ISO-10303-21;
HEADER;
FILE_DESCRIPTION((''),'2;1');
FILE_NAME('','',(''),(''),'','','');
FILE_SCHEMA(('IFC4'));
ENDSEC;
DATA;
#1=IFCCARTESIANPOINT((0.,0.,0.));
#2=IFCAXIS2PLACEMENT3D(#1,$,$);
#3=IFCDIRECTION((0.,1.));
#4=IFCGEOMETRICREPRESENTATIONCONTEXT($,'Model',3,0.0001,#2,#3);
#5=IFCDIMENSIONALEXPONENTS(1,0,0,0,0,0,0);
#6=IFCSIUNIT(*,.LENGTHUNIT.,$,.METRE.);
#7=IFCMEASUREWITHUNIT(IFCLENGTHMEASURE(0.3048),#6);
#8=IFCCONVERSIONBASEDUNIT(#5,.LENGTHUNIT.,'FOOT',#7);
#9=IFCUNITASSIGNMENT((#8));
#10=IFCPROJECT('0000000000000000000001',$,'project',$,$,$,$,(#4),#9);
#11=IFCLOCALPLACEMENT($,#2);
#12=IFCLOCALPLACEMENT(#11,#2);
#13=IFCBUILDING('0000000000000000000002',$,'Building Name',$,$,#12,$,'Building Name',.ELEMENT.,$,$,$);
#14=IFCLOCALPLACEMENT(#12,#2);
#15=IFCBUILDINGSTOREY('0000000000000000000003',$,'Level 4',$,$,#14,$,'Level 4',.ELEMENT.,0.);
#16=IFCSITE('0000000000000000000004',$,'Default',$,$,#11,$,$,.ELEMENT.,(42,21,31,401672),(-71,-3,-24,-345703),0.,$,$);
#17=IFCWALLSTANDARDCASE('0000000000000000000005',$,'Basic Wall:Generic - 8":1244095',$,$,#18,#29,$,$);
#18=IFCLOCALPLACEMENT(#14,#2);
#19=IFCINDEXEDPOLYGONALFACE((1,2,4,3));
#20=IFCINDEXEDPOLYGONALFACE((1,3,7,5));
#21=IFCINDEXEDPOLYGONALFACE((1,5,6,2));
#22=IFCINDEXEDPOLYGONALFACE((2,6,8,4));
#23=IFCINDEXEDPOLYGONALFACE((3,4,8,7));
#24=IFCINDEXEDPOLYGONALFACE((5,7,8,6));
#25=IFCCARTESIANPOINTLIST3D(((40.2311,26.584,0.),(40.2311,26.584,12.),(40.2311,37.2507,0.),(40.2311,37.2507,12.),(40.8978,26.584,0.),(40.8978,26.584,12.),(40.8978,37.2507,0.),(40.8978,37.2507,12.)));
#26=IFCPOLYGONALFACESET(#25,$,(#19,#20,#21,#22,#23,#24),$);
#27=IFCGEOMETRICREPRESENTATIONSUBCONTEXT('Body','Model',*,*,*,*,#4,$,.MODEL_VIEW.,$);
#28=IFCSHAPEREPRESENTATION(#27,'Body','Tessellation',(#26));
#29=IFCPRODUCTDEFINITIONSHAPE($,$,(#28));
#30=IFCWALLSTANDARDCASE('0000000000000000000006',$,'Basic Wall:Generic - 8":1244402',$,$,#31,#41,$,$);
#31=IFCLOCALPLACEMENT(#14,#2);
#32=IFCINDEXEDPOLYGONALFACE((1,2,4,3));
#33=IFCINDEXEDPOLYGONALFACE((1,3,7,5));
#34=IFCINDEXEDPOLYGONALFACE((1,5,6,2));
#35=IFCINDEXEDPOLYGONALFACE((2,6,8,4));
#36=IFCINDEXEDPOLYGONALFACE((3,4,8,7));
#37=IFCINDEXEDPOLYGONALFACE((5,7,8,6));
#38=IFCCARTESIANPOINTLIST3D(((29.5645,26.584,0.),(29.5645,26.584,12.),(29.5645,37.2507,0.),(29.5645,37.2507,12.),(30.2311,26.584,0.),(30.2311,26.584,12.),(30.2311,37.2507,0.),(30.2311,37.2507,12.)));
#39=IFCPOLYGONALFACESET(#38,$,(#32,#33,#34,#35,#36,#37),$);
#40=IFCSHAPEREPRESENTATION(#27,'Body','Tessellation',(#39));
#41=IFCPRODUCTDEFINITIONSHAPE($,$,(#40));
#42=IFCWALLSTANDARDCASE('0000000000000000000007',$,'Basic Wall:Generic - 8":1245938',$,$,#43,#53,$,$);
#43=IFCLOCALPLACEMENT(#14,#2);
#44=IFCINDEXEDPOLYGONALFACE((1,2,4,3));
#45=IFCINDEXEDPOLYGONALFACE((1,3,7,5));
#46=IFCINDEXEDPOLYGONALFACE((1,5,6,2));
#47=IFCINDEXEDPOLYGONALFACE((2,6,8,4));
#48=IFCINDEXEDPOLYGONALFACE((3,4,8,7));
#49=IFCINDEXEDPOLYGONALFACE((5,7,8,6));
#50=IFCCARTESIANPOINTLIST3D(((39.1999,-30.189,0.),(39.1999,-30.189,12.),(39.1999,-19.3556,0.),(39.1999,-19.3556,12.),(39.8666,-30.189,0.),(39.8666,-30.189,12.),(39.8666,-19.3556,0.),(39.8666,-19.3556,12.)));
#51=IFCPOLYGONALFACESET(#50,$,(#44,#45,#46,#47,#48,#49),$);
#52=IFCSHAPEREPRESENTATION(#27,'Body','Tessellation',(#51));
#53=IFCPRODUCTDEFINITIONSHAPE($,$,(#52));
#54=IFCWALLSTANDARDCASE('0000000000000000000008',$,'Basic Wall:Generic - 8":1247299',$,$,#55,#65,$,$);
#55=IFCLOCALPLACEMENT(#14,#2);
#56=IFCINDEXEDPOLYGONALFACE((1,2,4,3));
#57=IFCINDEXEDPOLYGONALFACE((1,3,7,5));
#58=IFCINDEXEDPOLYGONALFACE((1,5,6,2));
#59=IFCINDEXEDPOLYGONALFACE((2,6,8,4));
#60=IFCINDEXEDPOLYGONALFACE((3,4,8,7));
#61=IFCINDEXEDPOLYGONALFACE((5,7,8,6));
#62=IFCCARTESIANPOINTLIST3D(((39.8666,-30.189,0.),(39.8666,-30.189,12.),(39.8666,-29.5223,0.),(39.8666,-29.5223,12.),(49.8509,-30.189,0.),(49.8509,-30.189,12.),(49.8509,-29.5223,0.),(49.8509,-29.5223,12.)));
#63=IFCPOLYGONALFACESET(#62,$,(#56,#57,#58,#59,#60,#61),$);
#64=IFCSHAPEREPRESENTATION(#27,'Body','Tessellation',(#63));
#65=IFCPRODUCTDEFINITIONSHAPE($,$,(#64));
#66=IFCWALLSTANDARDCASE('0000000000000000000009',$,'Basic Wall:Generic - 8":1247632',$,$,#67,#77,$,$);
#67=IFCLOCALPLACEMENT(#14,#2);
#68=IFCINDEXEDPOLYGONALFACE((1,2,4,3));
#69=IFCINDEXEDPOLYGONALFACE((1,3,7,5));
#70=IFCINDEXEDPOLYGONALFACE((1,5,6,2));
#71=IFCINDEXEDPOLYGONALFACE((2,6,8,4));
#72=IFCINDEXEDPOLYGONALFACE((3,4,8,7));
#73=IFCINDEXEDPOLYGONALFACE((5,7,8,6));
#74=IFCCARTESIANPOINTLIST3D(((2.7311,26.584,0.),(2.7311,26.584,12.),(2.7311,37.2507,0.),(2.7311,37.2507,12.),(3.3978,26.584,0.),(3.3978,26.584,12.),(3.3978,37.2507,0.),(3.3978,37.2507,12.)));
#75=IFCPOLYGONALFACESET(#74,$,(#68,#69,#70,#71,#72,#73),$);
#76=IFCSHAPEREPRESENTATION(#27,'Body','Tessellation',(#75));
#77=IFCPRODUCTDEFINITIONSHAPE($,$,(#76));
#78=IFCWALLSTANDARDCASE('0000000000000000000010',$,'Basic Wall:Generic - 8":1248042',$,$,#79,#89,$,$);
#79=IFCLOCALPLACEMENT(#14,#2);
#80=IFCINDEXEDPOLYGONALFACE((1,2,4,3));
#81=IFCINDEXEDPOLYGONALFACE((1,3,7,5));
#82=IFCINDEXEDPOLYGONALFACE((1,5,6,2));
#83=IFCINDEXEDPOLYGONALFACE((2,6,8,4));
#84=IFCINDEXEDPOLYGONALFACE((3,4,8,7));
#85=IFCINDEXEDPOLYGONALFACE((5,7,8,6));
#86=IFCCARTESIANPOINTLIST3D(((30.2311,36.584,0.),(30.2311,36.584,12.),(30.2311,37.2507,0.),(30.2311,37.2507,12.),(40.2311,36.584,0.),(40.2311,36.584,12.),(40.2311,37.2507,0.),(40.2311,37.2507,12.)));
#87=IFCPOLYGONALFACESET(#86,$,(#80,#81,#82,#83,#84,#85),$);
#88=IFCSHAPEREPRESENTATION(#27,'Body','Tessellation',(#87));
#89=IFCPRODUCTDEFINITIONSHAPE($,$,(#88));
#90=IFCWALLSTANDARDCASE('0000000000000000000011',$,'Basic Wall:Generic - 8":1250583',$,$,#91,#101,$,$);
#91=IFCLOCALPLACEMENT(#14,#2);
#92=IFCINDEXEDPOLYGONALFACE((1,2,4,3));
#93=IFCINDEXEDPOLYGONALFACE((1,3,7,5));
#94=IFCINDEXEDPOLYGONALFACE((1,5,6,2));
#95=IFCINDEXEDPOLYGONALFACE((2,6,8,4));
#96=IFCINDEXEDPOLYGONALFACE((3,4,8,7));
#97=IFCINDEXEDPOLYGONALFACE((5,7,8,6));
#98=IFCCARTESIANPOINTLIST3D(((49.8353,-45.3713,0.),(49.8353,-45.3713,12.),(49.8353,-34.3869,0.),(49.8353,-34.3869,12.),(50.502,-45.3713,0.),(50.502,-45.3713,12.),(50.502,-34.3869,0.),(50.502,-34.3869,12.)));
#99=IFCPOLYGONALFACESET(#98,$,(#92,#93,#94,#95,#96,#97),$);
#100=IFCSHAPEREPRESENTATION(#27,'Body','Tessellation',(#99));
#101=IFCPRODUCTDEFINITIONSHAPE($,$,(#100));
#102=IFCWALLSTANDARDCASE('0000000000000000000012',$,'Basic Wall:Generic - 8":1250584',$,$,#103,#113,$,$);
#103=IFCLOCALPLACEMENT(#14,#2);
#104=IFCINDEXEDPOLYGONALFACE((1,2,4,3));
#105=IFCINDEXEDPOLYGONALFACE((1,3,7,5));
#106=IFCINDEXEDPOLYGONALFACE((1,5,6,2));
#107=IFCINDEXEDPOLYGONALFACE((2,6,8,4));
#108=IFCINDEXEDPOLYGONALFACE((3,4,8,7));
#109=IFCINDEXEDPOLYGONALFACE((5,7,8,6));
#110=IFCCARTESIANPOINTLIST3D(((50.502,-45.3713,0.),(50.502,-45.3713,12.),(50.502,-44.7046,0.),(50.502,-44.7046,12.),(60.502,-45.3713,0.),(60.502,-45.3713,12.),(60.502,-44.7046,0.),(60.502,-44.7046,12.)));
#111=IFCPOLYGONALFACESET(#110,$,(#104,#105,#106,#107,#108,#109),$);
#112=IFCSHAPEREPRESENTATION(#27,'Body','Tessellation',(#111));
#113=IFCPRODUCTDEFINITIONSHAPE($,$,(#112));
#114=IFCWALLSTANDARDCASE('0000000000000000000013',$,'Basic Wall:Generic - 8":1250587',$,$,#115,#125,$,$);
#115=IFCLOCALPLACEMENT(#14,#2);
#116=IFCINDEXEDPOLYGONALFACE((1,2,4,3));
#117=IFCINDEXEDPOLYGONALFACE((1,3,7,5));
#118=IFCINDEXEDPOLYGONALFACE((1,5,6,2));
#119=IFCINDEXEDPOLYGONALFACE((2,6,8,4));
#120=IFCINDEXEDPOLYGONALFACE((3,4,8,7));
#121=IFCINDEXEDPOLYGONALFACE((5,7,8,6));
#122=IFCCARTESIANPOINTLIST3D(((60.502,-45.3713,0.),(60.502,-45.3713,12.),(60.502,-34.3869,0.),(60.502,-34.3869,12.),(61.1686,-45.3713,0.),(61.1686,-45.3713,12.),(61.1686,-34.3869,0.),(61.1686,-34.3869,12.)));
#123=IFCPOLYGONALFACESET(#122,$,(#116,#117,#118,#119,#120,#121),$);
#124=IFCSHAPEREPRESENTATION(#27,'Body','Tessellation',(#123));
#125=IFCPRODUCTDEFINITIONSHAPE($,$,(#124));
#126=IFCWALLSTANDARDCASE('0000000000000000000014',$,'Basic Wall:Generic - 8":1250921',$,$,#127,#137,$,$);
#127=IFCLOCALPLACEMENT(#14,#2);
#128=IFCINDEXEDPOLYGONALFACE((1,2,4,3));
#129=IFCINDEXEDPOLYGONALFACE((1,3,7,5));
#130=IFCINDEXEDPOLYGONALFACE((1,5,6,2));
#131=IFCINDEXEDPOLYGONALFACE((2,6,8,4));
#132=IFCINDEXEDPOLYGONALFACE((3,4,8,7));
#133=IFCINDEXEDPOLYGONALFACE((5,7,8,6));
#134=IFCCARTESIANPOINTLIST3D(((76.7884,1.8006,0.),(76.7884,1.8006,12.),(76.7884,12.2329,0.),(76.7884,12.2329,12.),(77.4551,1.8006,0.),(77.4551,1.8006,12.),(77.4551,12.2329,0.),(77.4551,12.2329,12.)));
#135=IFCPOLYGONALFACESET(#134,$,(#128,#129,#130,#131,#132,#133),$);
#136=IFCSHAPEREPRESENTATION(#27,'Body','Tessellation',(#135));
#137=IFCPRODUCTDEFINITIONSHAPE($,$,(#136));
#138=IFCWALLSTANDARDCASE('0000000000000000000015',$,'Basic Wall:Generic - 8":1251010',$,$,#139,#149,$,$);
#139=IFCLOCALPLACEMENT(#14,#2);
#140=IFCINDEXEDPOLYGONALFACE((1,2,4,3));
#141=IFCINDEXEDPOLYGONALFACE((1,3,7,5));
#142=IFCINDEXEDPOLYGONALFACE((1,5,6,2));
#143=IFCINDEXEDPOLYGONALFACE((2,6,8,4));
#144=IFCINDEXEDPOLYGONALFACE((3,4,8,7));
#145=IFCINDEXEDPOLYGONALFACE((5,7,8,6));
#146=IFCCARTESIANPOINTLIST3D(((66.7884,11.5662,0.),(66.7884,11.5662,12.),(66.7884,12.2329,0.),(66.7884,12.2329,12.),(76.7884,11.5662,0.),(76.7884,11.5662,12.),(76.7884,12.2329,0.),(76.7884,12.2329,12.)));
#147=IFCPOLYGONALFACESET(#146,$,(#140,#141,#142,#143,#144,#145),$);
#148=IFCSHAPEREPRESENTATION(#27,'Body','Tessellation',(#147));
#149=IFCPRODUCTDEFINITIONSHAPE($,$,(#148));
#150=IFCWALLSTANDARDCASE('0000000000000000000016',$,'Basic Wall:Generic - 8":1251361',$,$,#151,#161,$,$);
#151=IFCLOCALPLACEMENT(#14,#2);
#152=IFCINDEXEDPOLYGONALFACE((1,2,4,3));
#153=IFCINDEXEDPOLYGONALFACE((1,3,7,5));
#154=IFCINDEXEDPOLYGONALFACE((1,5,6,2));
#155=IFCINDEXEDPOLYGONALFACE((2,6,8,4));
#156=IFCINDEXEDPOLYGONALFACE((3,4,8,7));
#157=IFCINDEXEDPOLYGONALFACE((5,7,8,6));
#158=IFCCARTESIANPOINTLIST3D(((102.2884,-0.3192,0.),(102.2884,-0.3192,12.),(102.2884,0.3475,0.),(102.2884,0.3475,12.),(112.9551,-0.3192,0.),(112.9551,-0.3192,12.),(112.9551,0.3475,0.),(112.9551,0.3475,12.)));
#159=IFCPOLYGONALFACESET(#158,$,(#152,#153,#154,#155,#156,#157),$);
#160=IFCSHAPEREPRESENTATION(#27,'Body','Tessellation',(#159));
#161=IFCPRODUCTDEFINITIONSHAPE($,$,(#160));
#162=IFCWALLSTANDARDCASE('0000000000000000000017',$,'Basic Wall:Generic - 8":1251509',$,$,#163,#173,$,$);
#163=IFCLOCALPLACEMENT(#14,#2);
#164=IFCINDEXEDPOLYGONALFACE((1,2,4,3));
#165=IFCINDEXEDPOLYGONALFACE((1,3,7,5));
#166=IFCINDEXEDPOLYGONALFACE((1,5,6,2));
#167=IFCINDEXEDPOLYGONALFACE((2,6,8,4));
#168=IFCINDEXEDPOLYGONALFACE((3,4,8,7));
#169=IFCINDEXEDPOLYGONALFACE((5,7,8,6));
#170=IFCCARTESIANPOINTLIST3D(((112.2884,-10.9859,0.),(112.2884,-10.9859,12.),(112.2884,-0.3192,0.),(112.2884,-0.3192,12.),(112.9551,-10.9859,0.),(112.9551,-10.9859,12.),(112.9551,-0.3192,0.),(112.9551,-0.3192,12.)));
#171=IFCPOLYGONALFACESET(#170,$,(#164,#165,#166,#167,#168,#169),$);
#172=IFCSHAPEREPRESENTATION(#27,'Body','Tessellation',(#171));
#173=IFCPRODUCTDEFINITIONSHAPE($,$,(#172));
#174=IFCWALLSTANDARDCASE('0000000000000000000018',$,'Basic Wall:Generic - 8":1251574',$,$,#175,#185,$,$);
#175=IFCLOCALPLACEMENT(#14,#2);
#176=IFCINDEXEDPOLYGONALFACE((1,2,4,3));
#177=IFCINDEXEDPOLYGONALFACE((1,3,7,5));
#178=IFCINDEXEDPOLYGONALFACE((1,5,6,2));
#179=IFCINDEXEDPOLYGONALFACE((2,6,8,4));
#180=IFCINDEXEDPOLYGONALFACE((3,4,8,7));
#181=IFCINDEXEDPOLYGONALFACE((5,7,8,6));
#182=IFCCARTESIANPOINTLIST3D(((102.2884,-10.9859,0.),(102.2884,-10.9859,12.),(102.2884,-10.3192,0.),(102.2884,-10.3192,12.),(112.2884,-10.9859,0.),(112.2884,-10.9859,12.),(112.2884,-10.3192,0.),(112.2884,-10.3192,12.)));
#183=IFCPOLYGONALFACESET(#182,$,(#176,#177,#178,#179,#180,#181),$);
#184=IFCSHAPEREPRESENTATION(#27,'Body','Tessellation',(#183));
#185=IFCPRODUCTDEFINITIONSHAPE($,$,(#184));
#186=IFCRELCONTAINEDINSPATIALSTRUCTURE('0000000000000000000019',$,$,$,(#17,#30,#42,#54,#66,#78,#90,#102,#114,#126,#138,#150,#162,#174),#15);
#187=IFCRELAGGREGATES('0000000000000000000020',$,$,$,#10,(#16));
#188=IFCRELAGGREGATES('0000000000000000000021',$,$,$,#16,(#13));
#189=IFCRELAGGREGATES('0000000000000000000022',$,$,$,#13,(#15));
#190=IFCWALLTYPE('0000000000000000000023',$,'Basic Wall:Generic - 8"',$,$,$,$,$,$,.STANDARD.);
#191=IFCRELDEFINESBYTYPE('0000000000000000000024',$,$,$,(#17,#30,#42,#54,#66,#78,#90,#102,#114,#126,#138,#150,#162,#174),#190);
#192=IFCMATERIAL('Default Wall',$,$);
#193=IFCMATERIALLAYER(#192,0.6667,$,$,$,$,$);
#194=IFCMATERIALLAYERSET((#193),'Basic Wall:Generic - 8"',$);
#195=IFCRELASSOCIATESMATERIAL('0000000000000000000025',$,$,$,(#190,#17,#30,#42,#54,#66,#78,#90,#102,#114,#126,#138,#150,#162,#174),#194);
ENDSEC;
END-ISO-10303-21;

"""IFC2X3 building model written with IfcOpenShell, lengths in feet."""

from ifc_helpers import new_model, entity, si_unit, converted_unit, direction, frame, frame_2d, origin, place, context, subcontext, project, spatial, rectangle, extrude, material, layer, layer_set, layer_usage, type_object, element, save


model = new_model("IFC2X3")

# Units and contexts
model_context = context("Model", 3, precision=0.0001, world=origin(), true_north=direction((0.0, 1.0)))
body_context = subcontext(model_context, "Body", "Model", "MODEL_VIEW")
ifc_project = project(units=[converted_unit("LENGTHUNIT", "FOOT", entity("IfcLengthMeasure", 0.3048), si_unit("LENGTHUNIT", "METRE"), dimensions=[1, 0, 0, 0, 0, 0, 0])], contexts=[model_context])

# Site, building, storey
site_placement = place(None, origin())
site = spatial("IfcSite", under=ifc_project, at=site_placement, Name="Default", CompositionType="ELEMENT", RefLatitude=(42, 21, 31, 401672), RefLongitude=(-71, -3, -24, -345703), RefElevation=0.0)
building_placement = place(site_placement, origin())
building = spatial("IfcBuilding", under=site, at=building_placement, Name="Building Name", LongName="Building Name", CompositionType="ELEMENT")
storey_placement = place(building_placement, origin())
storey = spatial("IfcBuildingStorey", under=building, at=storey_placement, Name="Level 4", LongName="Level 4", CompositionType="ELEMENT", Elevation=0.0)

# Walls
ifc_material_1 = material(Name="Default Wall")
ifc_layer_1 = layer(ifc_material_1, 0.6667)
ifc_layer_set_1 = layer_set([ifc_layer_1], Name="Basic Wall:Generic - 8\"")
ifc_layer_usage_1 = layer_usage(ifc_layer_set_1, "AXIS2", "POSITIVE", -0.3333)
wall_type_1 = type_object("IfcWallType", Name="Basic Wall:Generic - 8\"", PredefinedType="STANDARD", material=ifc_layer_set_1)
wall_1_placement = place(storey_placement, frame((40.5645, 26.584, 0.0), z_axis=(0.0, 0.0, 1.0), x_axis=(0.0, 1.0, 0.0)))
element("IfcWallStandardCase", 1, at=wall_1_placement, inside=storey, type_object=wall_type_1, material=ifc_layer_usage_1, Name="Basic Wall:Generic - 8\":1244095", context=body_context, shape_type="SweptSolid", body=[
    extrude(rectangle(XDim=10.6667, YDim=0.6667, at=frame_2d((5.3333, 0.0), x_axis=(-1.0, 0.0))), origin(), (0.0, 0.0, 1.0), 12.0),
])
ifc_layer_usage_2 = layer_usage(ifc_layer_set_1, "AXIS2", "NEGATIVE", 0.3333)
wall_2_placement = place(storey_placement, frame((29.8978, 26.584, 0.0), z_axis=(0.0, 0.0, 1.0), x_axis=(0.0, 1.0, 0.0)))
element("IfcWallStandardCase", 2, at=wall_2_placement, inside=storey, type_object=wall_type_1, material=ifc_layer_usage_2, Name="Basic Wall:Generic - 8\":1244402", context=body_context, shape_type="SweptSolid", body=[
    extrude(rectangle(XDim=10.6667, YDim=0.6667, at=frame_2d((5.3333, 0.0), x_axis=(-1.0, 0.0))), origin(), (0.0, 0.0, 1.0), 12.0),
])
ifc_layer_usage_3 = layer_usage(ifc_layer_set_1, "AXIS2", "POSITIVE", -0.3333)
wall_3_placement = place(storey_placement, frame((39.5332, -19.3556, 0.0), z_axis=(0.0, 0.0, 1.0), x_axis=(0.0, -1.0, 0.0)))
element("IfcWallStandardCase", 3, at=wall_3_placement, inside=storey, type_object=wall_type_1, material=ifc_layer_usage_3, Name="Basic Wall:Generic - 8\":1245938", context=body_context, shape_type="SweptSolid", body=[
    extrude(rectangle(XDim=10.8333, YDim=0.6667, at=frame_2d((5.4167, 0.0), x_axis=(-1.0, 0.0))), origin(), (0.0, 0.0, 1.0), 12.0),
])
ifc_layer_usage_4 = layer_usage(ifc_layer_set_1, "AXIS2", "NEGATIVE", 0.3333)
wall_4_placement = place(storey_placement, frame((39.8666, -29.8556, 0.0)))
element("IfcWallStandardCase", 4, at=wall_4_placement, inside=storey, type_object=wall_type_1, material=ifc_layer_usage_4, Name="Basic Wall:Generic - 8\":1247299", context=body_context, shape_type="SweptSolid", body=[
    extrude(rectangle(XDim=9.9844, YDim=0.6667, at=frame_2d((4.9922, 0.0), x_axis=(-1.0, 0.0))), origin(), (0.0, 0.0, 1.0), 12.0),
])
ifc_layer_usage_5 = layer_usage(ifc_layer_set_1, "AXIS2", "NEGATIVE", 0.3333)
wall_5_placement = place(storey_placement, frame((3.0645, 37.2507, 0.0), z_axis=(0.0, 0.0, 1.0), x_axis=(0.0, -1.0, 0.0)))
element("IfcWallStandardCase", 5, at=wall_5_placement, inside=storey, type_object=wall_type_1, material=ifc_layer_usage_5, Name="Basic Wall:Generic - 8\":1247632", context=body_context, shape_type="SweptSolid", body=[
    extrude(rectangle(XDim=10.6667, YDim=0.6667, at=frame_2d((5.3333, 0.0), x_axis=(-1.0, 0.0))), origin(), (0.0, 0.0, 1.0), 12.0),
])
ifc_layer_usage_6 = layer_usage(ifc_layer_set_1, "AXIS2", "NEGATIVE", 0.3333)
wall_6_placement = place(storey_placement, frame((30.2311, 36.9174, 0.0)))
element("IfcWallStandardCase", 6, at=wall_6_placement, inside=storey, type_object=wall_type_1, material=ifc_layer_usage_6, Name="Basic Wall:Generic - 8\":1248042", context=body_context, shape_type="SweptSolid", body=[
    extrude(rectangle(XDim=10.0, YDim=0.6667, at=frame_2d((5.0, 0.0), x_axis=(-1.0, 0.0))), origin(), (0.0, 0.0, 1.0), 12.0),
])
ifc_layer_usage_7 = layer_usage(ifc_layer_set_1, "AXIS2", "POSITIVE", -0.3333)
wall_7_placement = place(storey_placement, frame((50.1686, -34.3869, 0.0), z_axis=(0.0, 0.0, 1.0), x_axis=(0.0, -1.0, 0.0)))
element("IfcWallStandardCase", 7, at=wall_7_placement, inside=storey, type_object=wall_type_1, material=ifc_layer_usage_7, Name="Basic Wall:Generic - 8\":1250583", context=body_context, shape_type="SweptSolid", body=[
    extrude(rectangle(XDim=10.9844, YDim=0.6667, at=frame_2d((5.4922, 0.0), x_axis=(-1.0, 0.0))), origin(), (0.0, 0.0, 1.0), 12.0),
])
ifc_layer_usage_8 = layer_usage(ifc_layer_set_1, "AXIS2", "POSITIVE", -0.3333)
wall_8_placement = place(storey_placement, frame((50.502, -45.0379, 0.0)))
element("IfcWallStandardCase", 8, at=wall_8_placement, inside=storey, type_object=wall_type_1, material=ifc_layer_usage_8, Name="Basic Wall:Generic - 8\":1250584", context=body_context, shape_type="SweptSolid", body=[
    extrude(rectangle(XDim=10.0, YDim=0.6667, at=frame_2d((5.0, 0.0), x_axis=(-1.0, 0.0))), origin(), (0.0, 0.0, 1.0), 12.0),
])
ifc_layer_usage_9 = layer_usage(ifc_layer_set_1, "AXIS2", "NEGATIVE", 0.3333)
wall_9_placement = place(storey_placement, frame((60.8353, -34.3869, 0.0), z_axis=(0.0, 0.0, 1.0), x_axis=(0.0, -1.0, 0.0)))
element("IfcWallStandardCase", 9, at=wall_9_placement, inside=storey, type_object=wall_type_1, material=ifc_layer_usage_9, Name="Basic Wall:Generic - 8\":1250587", context=body_context, shape_type="SweptSolid", body=[
    extrude(rectangle(XDim=10.9844, YDim=0.6667, at=frame_2d((5.4922, 0.0), x_axis=(-1.0, 0.0))), origin(), (0.0, 0.0, 1.0), 12.0),
])
ifc_layer_usage_10 = layer_usage(ifc_layer_set_1, "AXIS2", "NEGATIVE", 0.3333)
wall_10_placement = place(storey_placement, frame((77.1218, 1.8006, 0.0), z_axis=(0.0, 0.0, 1.0), x_axis=(0.0, 1.0, 0.0)))
element("IfcWallStandardCase", 10, at=wall_10_placement, inside=storey, type_object=wall_type_1, material=ifc_layer_usage_10, Name="Basic Wall:Generic - 8\":1250921", context=body_context, shape_type="SweptSolid", body=[
    extrude(rectangle(XDim=10.4323, YDim=0.6667, at=frame_2d((5.2161, 0.0), x_axis=(-1.0, 0.0))), origin(), (0.0, 0.0, 1.0), 12.0),
])
ifc_layer_usage_11 = layer_usage(ifc_layer_set_1, "AXIS2", "NEGATIVE", 0.3333)
wall_11_placement = place(storey_placement, frame((76.7884, 11.8996, 0.0), z_axis=(0.0, 0.0, 1.0), x_axis=(-1.0, 0.0, 0.0)))
element("IfcWallStandardCase", 11, at=wall_11_placement, inside=storey, type_object=wall_type_1, material=ifc_layer_usage_11, Name="Basic Wall:Generic - 8\":1251010", context=body_context, shape_type="SweptSolid", body=[
    extrude(rectangle(XDim=10.0, YDim=0.6667, at=frame_2d((5.0, 0.0), x_axis=(-1.0, 0.0))), origin(), (0.0, 0.0, 1.0), 12.0),
])
ifc_layer_usage_12 = layer_usage(ifc_layer_set_1, "AXIS2", "NEGATIVE", 0.3333)
wall_12_placement = place(storey_placement, frame((102.2884, 0.0141, 0.0)))
element("IfcWallStandardCase", 12, at=wall_12_placement, inside=storey, type_object=wall_type_1, material=ifc_layer_usage_12, Name="Basic Wall:Generic - 8\":1251361", context=body_context, shape_type="SweptSolid", body=[
    extrude(rectangle(XDim=10.6667, YDim=0.6667, at=frame_2d((5.3333, 0.0), x_axis=(-1.0, 0.0))), origin(), (0.0, 0.0, 1.0), 12.0),
])
ifc_layer_usage_13 = layer_usage(ifc_layer_set_1, "AXIS2", "POSITIVE", -0.3333)
wall_13_placement = place(storey_placement, frame((112.6218, -0.3192, 0.0), z_axis=(0.0, 0.0, 1.0), x_axis=(0.0, -1.0, 0.0)))
element("IfcWallStandardCase", 13, at=wall_13_placement, inside=storey, type_object=wall_type_1, material=ifc_layer_usage_13, Name="Basic Wall:Generic - 8\":1251509", context=body_context, shape_type="SweptSolid", body=[
    extrude(rectangle(XDim=10.6667, YDim=0.6667, at=frame_2d((5.3333, 0.0), x_axis=(-1.0, 0.0))), origin(), (0.0, 0.0, 1.0), 12.0),
])
ifc_layer_usage_14 = layer_usage(ifc_layer_set_1, "AXIS2", "NEGATIVE", 0.3333)
wall_14_placement = place(storey_placement, frame((112.2884, -10.6525, 0.0), z_axis=(0.0, 0.0, 1.0), x_axis=(-1.0, 0.0, 0.0)))
element("IfcWallStandardCase", 14, at=wall_14_placement, inside=storey, type_object=wall_type_1, material=ifc_layer_usage_14, Name="Basic Wall:Generic - 8\":1251574", context=body_context, shape_type="SweptSolid", body=[
    extrude(rectangle(XDim=10.0, YDim=0.6667, at=frame_2d((5.0, 0.0), x_axis=(-1.0, 0.0))), origin(), (0.0, 0.0, 1.0), 12.0),
])

save(model, "model.ifc")
